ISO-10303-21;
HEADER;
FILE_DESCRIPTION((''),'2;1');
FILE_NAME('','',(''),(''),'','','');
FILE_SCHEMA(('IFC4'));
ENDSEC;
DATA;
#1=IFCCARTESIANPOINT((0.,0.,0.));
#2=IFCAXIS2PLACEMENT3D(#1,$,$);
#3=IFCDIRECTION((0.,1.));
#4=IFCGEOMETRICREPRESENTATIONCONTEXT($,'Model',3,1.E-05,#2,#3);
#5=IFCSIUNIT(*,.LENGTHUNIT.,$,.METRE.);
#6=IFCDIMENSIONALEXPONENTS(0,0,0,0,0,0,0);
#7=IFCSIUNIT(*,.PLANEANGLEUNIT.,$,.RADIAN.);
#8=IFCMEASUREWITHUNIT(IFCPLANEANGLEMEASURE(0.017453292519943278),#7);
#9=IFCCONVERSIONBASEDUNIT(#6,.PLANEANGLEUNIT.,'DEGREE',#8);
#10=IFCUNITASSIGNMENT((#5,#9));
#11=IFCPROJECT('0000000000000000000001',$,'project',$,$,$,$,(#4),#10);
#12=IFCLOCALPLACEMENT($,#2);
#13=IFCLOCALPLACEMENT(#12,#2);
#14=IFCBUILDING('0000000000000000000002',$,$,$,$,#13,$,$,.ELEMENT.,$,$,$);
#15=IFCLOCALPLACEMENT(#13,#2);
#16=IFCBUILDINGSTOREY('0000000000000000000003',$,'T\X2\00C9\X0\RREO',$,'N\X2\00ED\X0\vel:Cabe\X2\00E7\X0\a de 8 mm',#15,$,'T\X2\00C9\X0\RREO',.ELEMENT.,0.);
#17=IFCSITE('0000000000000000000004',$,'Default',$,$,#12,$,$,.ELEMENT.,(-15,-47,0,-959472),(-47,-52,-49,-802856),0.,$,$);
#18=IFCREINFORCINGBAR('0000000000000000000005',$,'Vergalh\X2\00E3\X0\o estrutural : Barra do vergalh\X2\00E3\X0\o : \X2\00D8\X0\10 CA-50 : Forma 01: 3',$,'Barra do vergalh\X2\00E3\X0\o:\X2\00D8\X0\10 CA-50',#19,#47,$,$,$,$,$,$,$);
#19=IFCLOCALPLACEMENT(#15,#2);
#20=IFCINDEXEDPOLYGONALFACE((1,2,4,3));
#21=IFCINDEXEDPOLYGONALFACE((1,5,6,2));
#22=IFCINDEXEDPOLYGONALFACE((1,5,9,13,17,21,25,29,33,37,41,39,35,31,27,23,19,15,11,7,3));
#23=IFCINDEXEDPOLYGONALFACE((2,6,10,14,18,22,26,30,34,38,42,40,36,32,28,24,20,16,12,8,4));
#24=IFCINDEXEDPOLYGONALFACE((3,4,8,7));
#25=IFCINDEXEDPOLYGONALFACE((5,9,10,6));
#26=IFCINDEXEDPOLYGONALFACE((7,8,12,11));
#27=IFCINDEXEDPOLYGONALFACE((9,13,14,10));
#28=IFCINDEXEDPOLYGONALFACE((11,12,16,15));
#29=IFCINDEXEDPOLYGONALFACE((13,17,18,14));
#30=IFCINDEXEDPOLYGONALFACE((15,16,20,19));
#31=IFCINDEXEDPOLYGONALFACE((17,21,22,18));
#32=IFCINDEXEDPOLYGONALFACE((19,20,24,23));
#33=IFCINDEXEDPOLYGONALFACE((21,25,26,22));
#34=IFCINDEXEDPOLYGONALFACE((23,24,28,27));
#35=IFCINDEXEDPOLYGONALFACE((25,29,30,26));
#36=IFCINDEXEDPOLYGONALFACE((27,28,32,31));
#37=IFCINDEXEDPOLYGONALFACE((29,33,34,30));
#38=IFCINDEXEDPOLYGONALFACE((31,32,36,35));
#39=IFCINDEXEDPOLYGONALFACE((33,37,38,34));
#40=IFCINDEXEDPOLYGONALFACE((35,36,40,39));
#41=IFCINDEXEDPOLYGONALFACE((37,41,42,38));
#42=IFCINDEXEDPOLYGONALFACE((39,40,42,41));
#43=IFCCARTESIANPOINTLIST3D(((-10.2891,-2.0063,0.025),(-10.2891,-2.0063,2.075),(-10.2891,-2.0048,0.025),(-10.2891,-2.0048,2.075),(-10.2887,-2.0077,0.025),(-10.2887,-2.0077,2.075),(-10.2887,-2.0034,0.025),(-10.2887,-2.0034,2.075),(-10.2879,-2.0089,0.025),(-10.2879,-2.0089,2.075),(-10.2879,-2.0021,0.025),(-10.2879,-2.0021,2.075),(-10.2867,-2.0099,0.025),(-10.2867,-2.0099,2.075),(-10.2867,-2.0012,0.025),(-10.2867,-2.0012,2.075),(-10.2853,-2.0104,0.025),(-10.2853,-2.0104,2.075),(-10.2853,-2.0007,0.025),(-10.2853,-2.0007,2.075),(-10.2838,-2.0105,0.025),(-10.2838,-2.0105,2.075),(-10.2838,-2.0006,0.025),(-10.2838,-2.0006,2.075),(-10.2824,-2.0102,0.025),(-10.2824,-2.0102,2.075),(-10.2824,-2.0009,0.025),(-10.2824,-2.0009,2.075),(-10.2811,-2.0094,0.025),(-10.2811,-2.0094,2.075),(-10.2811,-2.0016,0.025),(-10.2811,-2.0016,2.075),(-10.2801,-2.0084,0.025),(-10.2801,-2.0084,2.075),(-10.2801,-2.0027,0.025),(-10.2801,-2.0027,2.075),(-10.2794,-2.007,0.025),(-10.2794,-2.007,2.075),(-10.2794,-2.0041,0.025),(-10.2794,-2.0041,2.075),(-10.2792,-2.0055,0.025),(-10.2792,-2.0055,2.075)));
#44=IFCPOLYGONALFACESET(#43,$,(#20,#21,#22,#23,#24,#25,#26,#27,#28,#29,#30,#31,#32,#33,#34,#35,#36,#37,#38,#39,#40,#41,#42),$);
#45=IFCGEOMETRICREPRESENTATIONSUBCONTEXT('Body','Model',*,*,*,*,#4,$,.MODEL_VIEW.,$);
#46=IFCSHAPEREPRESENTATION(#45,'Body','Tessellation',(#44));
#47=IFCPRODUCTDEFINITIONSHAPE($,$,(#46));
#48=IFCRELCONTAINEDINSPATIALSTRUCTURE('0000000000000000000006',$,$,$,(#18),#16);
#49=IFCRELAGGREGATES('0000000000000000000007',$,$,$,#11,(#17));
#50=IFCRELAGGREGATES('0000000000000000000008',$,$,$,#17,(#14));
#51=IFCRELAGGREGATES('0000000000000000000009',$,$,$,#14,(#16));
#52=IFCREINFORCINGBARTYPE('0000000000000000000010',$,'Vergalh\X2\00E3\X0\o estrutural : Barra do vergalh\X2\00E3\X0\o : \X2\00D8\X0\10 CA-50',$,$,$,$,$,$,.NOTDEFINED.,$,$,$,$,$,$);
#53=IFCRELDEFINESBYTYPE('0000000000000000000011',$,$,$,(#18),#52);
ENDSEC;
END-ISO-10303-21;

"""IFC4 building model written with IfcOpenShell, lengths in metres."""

from ifc_helpers import new_model, entity, si_unit, converted_unit, direction, origin, place, context, subcontext, project, spatial, type_object, element, save


model = new_model("IFC4")

# Units and contexts
model_context = context("Model", 3, precision=1e-05, world=origin(), true_north=direction((0.0, 1.0)))
body_context = subcontext(model_context, "Body", "Model", "MODEL_VIEW")
ifc_project = project(units=[si_unit("LENGTHUNIT", "METRE"), converted_unit("PLANEANGLEUNIT", "DEGREE", entity("IfcPlaneAngleMeasure", 0.017453292519943278), si_unit("PLANEANGLEUNIT", "RADIAN"), dimensions=[0, 0, 0, 0, 0, 0, 0])], contexts=[model_context])

# Site, building, storey
site_placement = place(None, origin())
site = spatial("IfcSite", under=ifc_project, at=site_placement, Name="Default", CompositionType="ELEMENT", RefLatitude=(-15, -47, 0, -959472), RefLongitude=(-47, -52, -49, -802856), RefElevation=0.0)
building_placement = place(site_placement, origin())
building = spatial("IfcBuilding", under=site, at=building_placement, CompositionType="ELEMENT")
storey_placement = place(building_placement, origin())
storey = spatial("IfcBuildingStorey", under=building, at=storey_placement, Name="TÉRREO", ObjectType="Nível:Cabeça de 8 mm", LongName="TÉRREO", CompositionType="ELEMENT", Elevation=0.0)

# Reinforcing bar
reinforcing_bar_type_1 = type_object("IfcReinforcingBarType", Name="Vergalhão estrutural : Barra do vergalhão : Ø10 CA-50", PredefinedType="NOTDEFINED")
reinforcing_bar_1_placement = place(storey_placement, origin())
element("IfcReinforcingBar", 1, at=reinforcing_bar_1_placement, inside=storey, type_object=reinforcing_bar_type_1, Name="Vergalhão estrutural : Barra do vergalhão : Ø10 CA-50 : Forma 01: 3", ObjectType="Barra do vergalhão:Ø10 CA-50", context=body_context, shape_type="AdvancedSweptSolid", body=[
    entity("IfcSweptDiskSolid", entity("IfcIndexedPolyCurve", entity("IfcCartesianPointList3D", [[-10.2842, -2.0055, 0.025], [-10.2842, -2.0055, 2.075]]), None, False), 0.005, None, 0.0, 1.0),
])

save(model, "model.ifc")
